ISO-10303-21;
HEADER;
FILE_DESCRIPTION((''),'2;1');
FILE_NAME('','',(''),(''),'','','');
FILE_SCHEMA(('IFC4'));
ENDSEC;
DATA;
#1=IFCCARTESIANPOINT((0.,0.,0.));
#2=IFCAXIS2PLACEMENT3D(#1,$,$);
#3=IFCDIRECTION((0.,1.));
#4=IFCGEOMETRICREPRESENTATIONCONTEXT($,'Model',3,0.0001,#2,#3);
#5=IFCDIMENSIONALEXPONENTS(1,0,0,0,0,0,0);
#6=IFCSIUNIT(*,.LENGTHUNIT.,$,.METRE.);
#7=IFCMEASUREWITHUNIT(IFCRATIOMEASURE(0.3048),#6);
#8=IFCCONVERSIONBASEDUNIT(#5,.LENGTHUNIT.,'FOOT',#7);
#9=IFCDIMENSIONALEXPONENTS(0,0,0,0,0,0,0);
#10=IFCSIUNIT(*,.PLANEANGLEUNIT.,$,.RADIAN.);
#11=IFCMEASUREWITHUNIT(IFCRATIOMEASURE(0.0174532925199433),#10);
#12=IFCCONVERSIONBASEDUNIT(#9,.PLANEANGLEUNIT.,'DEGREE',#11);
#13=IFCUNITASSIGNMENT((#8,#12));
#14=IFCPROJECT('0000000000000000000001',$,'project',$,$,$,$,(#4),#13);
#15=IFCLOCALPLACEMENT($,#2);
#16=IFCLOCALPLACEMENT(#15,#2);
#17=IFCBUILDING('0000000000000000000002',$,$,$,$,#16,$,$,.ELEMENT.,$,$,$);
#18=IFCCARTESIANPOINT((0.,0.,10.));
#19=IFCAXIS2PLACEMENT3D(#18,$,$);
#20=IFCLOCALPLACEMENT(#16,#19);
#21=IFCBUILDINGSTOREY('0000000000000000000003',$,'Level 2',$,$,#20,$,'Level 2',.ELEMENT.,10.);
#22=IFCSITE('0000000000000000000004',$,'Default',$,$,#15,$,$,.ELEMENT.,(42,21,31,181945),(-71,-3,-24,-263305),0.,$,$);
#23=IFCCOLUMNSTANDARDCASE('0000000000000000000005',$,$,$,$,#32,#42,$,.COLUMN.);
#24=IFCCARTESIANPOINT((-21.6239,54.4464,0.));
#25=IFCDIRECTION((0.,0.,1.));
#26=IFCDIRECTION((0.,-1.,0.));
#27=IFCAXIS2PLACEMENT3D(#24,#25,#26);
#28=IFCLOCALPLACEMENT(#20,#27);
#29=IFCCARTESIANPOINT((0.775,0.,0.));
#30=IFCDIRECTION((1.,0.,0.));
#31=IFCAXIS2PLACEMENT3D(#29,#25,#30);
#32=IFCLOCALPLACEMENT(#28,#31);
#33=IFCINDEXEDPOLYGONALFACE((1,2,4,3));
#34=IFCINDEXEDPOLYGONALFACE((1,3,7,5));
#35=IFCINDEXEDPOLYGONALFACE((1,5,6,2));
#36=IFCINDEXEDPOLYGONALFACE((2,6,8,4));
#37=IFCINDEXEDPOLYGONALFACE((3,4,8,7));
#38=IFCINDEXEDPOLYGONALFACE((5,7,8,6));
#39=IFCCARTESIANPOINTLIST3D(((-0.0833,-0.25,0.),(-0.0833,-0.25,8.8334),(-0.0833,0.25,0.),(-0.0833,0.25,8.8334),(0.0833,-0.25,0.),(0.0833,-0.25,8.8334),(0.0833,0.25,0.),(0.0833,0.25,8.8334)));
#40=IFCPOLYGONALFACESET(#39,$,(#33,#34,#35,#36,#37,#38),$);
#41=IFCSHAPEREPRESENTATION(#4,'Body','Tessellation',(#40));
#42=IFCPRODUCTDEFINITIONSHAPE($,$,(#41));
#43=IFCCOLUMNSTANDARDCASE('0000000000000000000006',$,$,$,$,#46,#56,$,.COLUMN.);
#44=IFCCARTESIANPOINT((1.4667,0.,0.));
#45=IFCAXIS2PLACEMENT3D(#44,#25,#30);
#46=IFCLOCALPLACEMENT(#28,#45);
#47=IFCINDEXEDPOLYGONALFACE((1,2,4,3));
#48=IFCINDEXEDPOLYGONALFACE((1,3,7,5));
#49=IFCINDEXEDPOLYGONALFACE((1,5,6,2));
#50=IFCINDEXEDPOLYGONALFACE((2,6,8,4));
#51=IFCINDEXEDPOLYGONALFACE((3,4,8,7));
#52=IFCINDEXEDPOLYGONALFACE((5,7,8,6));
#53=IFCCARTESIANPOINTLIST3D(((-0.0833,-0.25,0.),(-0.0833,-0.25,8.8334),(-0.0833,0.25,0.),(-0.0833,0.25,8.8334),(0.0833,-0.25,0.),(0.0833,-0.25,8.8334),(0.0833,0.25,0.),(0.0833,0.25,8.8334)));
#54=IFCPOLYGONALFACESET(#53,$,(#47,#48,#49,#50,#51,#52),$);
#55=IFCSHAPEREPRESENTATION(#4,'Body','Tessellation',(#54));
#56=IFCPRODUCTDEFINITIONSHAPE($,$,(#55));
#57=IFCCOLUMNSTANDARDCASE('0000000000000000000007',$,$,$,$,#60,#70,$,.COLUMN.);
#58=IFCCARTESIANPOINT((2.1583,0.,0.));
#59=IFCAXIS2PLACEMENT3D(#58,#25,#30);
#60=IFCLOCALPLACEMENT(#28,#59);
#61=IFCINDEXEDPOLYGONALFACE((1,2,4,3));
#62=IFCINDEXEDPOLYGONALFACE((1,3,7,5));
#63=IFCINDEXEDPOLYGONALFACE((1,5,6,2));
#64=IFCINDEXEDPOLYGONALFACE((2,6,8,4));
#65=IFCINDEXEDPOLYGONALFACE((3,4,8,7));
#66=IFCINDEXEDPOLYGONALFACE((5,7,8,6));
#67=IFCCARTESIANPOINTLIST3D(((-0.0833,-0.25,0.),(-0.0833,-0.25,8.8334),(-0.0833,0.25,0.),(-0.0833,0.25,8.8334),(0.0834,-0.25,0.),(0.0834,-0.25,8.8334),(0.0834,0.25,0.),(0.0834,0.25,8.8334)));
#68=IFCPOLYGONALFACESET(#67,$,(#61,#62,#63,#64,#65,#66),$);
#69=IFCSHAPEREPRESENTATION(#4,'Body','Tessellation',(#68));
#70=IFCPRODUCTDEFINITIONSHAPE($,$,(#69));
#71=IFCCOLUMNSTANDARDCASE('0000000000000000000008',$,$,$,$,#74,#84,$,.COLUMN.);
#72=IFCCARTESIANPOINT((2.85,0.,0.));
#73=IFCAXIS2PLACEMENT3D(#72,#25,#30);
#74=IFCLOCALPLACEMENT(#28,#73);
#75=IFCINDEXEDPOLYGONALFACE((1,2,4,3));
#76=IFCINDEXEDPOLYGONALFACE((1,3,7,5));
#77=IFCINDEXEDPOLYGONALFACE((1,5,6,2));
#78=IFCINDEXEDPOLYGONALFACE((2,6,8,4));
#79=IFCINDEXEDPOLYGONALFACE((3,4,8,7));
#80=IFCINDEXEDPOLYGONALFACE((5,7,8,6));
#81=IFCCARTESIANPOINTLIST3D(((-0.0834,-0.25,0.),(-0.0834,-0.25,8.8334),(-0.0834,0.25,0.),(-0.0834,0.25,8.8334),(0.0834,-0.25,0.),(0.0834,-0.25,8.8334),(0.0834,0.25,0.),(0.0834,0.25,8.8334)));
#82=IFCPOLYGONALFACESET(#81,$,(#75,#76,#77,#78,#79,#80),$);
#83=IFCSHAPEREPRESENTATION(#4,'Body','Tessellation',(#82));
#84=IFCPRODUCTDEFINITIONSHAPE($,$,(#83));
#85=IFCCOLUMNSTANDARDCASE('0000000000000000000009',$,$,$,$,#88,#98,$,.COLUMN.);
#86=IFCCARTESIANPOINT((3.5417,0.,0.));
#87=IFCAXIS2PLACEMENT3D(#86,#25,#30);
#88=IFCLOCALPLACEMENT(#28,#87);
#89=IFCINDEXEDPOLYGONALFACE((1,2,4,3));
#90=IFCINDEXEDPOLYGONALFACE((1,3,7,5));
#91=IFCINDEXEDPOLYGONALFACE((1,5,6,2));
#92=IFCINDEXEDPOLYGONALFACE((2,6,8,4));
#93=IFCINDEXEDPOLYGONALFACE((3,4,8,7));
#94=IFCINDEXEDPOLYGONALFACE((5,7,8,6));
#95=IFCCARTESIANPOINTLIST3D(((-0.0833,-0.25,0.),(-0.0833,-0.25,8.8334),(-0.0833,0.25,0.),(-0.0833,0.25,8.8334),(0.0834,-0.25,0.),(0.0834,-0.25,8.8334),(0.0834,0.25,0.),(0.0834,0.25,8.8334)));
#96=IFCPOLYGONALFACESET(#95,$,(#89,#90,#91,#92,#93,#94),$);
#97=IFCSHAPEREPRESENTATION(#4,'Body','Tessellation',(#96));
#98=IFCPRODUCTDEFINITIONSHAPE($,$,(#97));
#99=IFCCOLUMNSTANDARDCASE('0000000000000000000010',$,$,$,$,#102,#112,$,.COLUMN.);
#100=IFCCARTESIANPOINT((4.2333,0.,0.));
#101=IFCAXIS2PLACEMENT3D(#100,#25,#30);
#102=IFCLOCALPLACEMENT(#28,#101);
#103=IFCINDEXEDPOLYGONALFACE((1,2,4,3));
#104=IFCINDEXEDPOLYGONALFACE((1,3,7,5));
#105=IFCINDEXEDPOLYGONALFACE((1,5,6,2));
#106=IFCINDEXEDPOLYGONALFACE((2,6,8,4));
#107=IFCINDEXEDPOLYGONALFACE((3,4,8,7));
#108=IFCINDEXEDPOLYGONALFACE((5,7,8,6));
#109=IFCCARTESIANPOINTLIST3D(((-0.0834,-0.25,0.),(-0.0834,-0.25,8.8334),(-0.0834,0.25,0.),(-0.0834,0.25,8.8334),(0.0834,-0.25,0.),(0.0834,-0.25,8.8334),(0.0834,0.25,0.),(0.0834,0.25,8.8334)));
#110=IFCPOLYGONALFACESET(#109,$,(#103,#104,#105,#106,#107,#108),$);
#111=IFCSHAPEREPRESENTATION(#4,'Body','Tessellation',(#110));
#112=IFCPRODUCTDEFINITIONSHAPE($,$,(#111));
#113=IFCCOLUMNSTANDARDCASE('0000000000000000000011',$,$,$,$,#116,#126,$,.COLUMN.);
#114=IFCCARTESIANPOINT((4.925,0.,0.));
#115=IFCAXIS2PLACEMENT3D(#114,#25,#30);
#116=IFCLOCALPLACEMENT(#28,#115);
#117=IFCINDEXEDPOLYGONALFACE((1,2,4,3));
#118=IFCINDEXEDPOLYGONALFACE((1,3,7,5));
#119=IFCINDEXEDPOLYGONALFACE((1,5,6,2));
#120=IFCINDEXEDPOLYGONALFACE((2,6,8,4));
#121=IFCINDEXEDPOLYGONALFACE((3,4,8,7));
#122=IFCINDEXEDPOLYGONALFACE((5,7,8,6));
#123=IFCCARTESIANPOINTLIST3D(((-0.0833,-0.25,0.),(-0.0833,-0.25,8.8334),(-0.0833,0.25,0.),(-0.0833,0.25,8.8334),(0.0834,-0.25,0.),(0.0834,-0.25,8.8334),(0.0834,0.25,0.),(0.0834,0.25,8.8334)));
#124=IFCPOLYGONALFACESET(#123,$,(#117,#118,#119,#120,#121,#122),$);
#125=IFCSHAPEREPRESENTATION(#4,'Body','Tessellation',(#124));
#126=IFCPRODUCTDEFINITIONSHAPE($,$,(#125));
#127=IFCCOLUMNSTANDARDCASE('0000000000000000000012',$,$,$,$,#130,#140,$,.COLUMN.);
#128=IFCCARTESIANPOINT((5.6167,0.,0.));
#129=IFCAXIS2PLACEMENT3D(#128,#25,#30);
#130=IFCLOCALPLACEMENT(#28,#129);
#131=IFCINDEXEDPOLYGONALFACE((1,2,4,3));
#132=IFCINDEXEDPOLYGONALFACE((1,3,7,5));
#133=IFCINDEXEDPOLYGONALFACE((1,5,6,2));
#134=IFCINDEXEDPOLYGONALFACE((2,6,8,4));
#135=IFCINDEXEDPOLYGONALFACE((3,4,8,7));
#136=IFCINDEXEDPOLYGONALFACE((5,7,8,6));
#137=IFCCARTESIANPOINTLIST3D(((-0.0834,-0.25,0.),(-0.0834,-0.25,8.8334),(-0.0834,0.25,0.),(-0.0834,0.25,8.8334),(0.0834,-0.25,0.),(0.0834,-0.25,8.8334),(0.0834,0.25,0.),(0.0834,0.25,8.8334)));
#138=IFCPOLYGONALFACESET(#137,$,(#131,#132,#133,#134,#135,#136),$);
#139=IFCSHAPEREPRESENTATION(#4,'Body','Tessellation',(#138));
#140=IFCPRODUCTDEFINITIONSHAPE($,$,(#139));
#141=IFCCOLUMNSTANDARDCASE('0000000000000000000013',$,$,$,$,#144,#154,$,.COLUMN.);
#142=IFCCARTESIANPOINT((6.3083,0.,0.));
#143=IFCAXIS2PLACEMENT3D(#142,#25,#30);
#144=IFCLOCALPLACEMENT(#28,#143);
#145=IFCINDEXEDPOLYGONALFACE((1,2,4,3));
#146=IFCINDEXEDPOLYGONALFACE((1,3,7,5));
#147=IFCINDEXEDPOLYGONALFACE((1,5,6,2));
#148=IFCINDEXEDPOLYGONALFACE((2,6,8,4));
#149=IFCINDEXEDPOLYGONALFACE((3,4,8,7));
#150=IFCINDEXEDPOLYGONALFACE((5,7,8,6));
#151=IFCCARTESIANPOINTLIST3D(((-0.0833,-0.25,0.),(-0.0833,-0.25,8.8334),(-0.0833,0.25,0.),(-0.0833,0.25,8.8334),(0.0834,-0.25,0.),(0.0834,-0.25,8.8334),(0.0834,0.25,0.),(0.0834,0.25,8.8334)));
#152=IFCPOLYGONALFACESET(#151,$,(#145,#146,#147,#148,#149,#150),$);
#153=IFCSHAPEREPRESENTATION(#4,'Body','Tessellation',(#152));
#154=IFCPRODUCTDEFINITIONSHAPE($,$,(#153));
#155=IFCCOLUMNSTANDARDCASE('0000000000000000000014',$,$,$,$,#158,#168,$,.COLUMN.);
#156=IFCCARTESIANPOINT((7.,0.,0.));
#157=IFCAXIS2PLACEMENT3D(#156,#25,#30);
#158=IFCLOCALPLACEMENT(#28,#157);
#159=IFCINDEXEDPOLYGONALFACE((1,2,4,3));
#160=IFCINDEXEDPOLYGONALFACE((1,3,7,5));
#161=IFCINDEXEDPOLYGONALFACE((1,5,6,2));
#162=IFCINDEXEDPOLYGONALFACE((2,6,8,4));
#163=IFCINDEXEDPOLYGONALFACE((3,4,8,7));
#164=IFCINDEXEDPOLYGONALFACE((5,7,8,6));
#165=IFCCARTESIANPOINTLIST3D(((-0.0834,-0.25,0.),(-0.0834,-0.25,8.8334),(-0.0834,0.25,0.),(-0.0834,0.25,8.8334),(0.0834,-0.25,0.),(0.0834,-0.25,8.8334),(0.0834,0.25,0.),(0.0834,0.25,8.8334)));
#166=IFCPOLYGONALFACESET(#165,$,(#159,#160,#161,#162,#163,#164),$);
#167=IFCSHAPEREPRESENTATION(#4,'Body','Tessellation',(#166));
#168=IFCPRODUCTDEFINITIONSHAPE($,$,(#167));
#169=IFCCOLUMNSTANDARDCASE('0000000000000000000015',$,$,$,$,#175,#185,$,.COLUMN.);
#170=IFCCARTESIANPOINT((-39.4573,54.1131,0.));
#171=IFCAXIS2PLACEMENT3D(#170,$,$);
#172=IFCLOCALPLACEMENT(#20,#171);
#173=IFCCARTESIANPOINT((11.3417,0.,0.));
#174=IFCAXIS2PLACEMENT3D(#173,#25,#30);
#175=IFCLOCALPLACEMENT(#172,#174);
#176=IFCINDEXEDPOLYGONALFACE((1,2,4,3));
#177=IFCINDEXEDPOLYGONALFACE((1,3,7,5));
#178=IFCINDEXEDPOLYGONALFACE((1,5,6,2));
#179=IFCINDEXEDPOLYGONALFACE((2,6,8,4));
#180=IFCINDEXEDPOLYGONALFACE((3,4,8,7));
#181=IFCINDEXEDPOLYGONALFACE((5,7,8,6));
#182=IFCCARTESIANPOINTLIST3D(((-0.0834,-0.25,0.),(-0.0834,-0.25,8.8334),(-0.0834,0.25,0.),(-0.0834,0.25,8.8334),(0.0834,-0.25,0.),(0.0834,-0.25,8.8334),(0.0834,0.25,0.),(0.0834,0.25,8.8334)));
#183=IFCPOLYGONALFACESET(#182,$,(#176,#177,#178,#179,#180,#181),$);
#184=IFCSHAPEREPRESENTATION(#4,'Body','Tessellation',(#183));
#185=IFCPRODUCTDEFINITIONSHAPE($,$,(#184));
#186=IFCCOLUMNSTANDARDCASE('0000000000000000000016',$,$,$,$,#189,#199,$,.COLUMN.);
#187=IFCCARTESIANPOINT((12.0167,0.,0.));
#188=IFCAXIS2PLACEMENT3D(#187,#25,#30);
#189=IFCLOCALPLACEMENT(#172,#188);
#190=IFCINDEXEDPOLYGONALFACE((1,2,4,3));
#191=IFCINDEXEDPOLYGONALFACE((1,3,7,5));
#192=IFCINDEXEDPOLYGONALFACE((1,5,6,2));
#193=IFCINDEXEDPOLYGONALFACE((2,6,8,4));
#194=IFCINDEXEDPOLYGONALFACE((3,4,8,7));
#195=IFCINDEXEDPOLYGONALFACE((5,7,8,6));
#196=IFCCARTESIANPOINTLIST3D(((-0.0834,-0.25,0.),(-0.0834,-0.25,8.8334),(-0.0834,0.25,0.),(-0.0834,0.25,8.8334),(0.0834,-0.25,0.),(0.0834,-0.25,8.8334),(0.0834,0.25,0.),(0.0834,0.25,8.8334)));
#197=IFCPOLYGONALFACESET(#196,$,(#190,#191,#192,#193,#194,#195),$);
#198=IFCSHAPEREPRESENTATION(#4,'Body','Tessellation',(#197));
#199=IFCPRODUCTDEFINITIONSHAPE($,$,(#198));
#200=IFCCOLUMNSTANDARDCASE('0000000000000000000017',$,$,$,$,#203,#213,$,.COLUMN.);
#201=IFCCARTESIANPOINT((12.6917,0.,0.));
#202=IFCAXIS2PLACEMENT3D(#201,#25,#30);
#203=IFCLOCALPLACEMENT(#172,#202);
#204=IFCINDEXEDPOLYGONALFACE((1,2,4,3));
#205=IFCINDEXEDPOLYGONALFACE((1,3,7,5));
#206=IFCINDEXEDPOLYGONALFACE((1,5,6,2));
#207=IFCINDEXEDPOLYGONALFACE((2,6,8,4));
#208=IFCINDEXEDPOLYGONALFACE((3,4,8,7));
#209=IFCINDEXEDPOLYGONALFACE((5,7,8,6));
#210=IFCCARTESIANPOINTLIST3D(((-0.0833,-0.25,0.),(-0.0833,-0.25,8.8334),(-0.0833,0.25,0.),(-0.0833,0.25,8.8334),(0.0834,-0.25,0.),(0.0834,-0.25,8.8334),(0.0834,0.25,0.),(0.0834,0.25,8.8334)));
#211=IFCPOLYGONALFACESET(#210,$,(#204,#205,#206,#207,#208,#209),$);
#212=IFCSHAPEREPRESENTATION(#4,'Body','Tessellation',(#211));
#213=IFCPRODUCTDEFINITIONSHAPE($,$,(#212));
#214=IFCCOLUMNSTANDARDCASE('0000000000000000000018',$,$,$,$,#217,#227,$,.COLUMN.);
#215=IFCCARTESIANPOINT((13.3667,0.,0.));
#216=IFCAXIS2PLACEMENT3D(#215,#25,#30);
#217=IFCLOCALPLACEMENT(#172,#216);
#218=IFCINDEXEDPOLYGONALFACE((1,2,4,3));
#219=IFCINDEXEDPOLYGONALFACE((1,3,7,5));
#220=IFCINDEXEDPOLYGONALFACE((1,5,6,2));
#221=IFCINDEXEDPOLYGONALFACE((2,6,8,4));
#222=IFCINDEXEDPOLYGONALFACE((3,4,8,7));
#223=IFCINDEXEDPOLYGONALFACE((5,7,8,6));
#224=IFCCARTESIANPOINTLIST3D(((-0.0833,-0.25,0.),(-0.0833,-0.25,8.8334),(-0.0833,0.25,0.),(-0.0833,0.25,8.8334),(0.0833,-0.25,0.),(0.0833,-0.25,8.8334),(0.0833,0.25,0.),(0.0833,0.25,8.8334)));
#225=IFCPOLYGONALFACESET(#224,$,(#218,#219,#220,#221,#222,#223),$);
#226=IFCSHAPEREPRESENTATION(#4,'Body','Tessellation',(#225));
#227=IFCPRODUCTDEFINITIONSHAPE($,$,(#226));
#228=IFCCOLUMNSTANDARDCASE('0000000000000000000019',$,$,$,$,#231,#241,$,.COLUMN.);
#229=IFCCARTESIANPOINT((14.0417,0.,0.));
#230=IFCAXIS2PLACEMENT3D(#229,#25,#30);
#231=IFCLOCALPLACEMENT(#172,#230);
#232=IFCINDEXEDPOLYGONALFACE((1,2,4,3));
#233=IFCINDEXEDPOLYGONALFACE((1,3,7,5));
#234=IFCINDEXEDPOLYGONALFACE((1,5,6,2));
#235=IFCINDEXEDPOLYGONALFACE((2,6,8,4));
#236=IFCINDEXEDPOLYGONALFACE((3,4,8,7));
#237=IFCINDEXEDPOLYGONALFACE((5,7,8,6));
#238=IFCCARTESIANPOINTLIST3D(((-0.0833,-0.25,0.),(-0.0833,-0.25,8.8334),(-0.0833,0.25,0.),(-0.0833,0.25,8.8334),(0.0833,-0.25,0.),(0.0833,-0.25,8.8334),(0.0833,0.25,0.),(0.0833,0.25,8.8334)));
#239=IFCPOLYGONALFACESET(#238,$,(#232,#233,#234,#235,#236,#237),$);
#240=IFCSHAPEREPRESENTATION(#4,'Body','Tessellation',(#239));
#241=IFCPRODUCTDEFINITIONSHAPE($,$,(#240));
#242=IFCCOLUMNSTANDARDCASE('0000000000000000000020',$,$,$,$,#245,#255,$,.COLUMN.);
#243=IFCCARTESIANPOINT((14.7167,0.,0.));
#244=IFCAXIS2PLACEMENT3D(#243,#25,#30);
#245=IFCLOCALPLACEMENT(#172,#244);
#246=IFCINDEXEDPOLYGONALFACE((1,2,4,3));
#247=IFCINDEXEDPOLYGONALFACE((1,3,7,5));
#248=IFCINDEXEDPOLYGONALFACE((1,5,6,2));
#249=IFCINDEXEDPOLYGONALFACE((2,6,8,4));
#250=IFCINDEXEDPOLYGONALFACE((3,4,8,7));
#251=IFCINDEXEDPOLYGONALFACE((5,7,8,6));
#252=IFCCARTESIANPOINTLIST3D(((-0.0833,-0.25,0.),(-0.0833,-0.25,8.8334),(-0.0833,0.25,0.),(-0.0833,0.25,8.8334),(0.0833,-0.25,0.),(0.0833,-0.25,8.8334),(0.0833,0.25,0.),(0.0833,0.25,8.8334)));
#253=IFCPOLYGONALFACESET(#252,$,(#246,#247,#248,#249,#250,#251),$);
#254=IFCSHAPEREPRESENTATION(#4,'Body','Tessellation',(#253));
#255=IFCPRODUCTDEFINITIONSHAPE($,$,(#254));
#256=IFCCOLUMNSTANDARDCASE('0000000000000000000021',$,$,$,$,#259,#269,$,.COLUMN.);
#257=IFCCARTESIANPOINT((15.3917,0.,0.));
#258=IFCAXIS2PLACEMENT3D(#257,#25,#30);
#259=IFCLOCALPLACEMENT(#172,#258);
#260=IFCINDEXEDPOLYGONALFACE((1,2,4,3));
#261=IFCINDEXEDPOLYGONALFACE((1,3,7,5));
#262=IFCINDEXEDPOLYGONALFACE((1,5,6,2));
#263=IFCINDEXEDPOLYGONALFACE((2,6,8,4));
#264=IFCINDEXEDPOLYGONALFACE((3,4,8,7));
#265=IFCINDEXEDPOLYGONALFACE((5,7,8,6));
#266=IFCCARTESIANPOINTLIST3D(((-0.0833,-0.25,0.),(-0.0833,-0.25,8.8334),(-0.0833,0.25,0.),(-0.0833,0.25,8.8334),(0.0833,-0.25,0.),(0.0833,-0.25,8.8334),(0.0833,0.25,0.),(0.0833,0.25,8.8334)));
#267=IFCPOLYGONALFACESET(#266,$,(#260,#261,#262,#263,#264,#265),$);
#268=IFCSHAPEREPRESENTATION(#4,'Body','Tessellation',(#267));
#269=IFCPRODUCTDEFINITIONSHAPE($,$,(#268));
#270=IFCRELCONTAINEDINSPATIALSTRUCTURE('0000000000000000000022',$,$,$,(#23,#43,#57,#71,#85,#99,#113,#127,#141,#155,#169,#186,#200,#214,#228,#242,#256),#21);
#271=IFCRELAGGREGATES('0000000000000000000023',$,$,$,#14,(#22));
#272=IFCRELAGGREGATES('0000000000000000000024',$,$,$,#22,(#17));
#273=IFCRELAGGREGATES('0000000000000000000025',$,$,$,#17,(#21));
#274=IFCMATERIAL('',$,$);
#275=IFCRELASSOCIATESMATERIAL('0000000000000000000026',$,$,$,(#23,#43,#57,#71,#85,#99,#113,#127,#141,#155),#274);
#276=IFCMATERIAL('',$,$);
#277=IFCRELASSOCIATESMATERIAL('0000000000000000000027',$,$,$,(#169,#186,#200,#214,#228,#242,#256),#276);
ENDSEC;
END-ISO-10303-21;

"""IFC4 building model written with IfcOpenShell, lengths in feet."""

from ifc_helpers import new_model, entity, si_unit, converted_unit, direction, frame, origin, place, context, project, spatial, rectangle, extrude, material, element, save


model = new_model("IFC4")

# Units and contexts
model_context = context("Model", 3, precision=0.0001, world=origin(), true_north=direction((0.0, 1.0)))
ifc_project = project(units=[converted_unit("LENGTHUNIT", "FOOT", entity("IfcRatioMeasure", 0.3048), si_unit("LENGTHUNIT", "METRE"), dimensions=[1, 0, 0, 0, 0, 0, 0]), converted_unit("PLANEANGLEUNIT", "DEGREE", entity("IfcRatioMeasure", 0.0174532925199433), si_unit("PLANEANGLEUNIT", "RADIAN"), dimensions=[0, 0, 0, 0, 0, 0, 0])], contexts=[model_context])

# Site, building, storey
site_placement = place(None, origin())
site = spatial("IfcSite", under=ifc_project, at=site_placement, Name="Default", CompositionType="ELEMENT", RefLatitude=(42, 21, 31, 181945), RefLongitude=(-71, -3, -24, -263305), RefElevation=0.0)
building_placement = place(site_placement, origin())
building = spatial("IfcBuilding", under=site, at=building_placement, CompositionType="ELEMENT")
storey_placement = place(building_placement, frame((0.0, 0.0, 10.0)))
storey = spatial("IfcBuildingStorey", under=building, at=storey_placement, Name="Level 2", LongName="Level 2", CompositionType="ELEMENT", Elevation=10.0)

# Columns
ifc_material_1 = material(Name="")
placement_1 = place(storey_placement, frame((-21.6239, 54.4464, 0.0), z_axis=(0.0, 0.0, 1.0), x_axis=(0.0, -1.0, 0.0)))
for number, where, z_axis, x_axis in (
    (1, (0.775, 0.0, 0.0), (0.0, 0.0, 1.0), (1.0, 0.0, 0.0)),
    (2, (1.4667, 0.0, 0.0), (0.0, 0.0, 1.0), (1.0, 0.0, 0.0)),
    (3, (2.1583, 0.0, 0.0), (0.0, 0.0, 1.0), (1.0, 0.0, 0.0)),
    (4, (2.85, 0.0, 0.0), (0.0, 0.0, 1.0), (1.0, 0.0, 0.0)),
    (5, (3.5417, 0.0, 0.0), (0.0, 0.0, 1.0), (1.0, 0.0, 0.0)),
    (6, (4.2333, 0.0, 0.0), (0.0, 0.0, 1.0), (1.0, 0.0, 0.0)),
    (7, (4.925, 0.0, 0.0), (0.0, 0.0, 1.0), (1.0, 0.0, 0.0)),
    (8, (5.6167, 0.0, 0.0), (0.0, 0.0, 1.0), (1.0, 0.0, 0.0)),
    (9, (6.3083, 0.0, 0.0), (0.0, 0.0, 1.0), (1.0, 0.0, 0.0)),
    (10, (7.0, 0.0, 0.0), (0.0, 0.0, 1.0), (1.0, 0.0, 0.0)),
):
    element("IfcColumnStandardCase", number, at=place(placement_1, frame(where, z_axis=z_axis, x_axis=x_axis)), inside=storey, material=ifc_material_1, PredefinedType="COLUMN", context=model_context, shape_type="SweptSolid", body=[
        extrude(rectangle(XDim=0.1667, YDim=0.5), origin(), (0.0, 0.0, 1.0), 8.8334),
    ])
ifc_material_2 = material(Name="")
placement_2 = place(storey_placement, frame((-39.4573, 54.1131, 0.0)))
for number, where, z_axis, x_axis in (
    (11, (11.3417, 0.0, 0.0), (0.0, 0.0, 1.0), (1.0, 0.0, 0.0)),
    (12, (12.0167, 0.0, 0.0), (0.0, 0.0, 1.0), (1.0, 0.0, 0.0)),
    (13, (12.6917, 0.0, 0.0), (0.0, 0.0, 1.0), (1.0, 0.0, 0.0)),
    (14, (13.3667, 0.0, 0.0), (0.0, 0.0, 1.0), (1.0, 0.0, 0.0)),
    (15, (14.0417, 0.0, 0.0), (0.0, 0.0, 1.0), (1.0, 0.0, 0.0)),
    (16, (14.7167, 0.0, 0.0), (0.0, 0.0, 1.0), (1.0, 0.0, 0.0)),
    (17, (15.3917, 0.0, 0.0), (0.0, 0.0, 1.0), (1.0, 0.0, 0.0)),
):
    element("IfcColumnStandardCase", number, at=place(placement_2, frame(where, z_axis=z_axis, x_axis=x_axis)), inside=storey, material=ifc_material_2, PredefinedType="COLUMN", context=model_context, shape_type="SweptSolid", body=[
        extrude(rectangle(XDim=0.1667, YDim=0.5), origin(), (0.0, 0.0, 1.0), 8.8334),
    ])

save(model, "model.ifc")
